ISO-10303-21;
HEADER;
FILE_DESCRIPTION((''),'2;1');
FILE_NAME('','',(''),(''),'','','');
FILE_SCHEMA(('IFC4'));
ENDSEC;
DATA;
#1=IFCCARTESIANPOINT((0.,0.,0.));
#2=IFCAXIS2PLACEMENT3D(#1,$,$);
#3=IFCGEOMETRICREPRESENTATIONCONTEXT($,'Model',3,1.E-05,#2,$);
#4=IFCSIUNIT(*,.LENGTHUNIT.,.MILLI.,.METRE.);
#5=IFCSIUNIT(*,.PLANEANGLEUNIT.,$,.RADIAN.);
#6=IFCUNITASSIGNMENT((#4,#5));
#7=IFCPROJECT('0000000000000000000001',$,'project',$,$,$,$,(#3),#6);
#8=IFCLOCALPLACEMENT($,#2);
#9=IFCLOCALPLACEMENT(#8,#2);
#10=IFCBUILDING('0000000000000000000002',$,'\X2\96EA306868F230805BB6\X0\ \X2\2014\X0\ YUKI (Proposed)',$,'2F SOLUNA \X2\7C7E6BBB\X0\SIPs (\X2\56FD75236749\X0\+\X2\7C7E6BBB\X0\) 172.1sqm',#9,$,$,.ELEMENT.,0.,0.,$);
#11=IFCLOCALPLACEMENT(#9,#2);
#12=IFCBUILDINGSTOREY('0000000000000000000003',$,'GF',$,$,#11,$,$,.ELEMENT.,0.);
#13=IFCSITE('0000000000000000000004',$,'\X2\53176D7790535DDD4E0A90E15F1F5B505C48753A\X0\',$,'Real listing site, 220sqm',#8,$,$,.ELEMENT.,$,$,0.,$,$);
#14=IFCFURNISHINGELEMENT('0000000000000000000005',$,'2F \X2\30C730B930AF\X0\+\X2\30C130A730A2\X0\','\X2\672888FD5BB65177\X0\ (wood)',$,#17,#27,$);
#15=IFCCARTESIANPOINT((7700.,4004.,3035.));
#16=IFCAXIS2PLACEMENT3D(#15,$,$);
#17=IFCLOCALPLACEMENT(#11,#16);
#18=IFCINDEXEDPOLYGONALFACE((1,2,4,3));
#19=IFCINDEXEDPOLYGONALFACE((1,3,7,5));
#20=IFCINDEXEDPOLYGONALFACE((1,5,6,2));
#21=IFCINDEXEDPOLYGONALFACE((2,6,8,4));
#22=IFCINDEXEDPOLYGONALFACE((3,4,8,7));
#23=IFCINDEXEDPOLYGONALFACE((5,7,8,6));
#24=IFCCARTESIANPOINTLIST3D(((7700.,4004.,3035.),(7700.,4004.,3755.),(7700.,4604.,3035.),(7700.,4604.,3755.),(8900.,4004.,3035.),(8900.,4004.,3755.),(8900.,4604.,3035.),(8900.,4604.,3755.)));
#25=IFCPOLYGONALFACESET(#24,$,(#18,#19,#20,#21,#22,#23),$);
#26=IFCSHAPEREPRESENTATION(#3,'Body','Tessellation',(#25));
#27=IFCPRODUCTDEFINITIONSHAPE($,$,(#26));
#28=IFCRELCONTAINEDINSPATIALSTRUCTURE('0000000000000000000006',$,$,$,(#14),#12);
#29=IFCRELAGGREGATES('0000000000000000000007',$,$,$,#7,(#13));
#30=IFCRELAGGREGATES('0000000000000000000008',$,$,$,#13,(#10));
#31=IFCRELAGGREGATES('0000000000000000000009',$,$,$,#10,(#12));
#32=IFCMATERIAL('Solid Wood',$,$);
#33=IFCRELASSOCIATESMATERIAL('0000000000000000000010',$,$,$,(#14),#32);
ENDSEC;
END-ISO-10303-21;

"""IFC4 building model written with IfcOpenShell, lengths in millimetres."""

from ifc_helpers import new_model, si_unit, frame, frame_2d, origin, place, context, project, spatial, rectangle, extrude, material, element, save


model = new_model("IFC4")

# Units and contexts
model_context = context("Model", 3, precision=1e-05, world=origin())
ifc_project = project(units=[si_unit("LENGTHUNIT", "METRE", prefix="MILLI"), si_unit("PLANEANGLEUNIT", "RADIAN")], contexts=[model_context])

# Site, building, storey
site_placement = place(None, origin())
site = spatial("IfcSite", under=ifc_project, at=site_placement, Name="北海道川上郡弟子屈町", ObjectType="Real listing site, 220sqm", CompositionType="ELEMENT", RefElevation=0.0)
building_placement = place(site_placement, origin())
building = spatial("IfcBuilding", under=site, at=building_placement, Name="雪と棲む家 — YUKI (Proposed)", ObjectType="2F SOLUNA 籾殻SIPs (国産杉+籾殻) 172.1sqm", CompositionType="ELEMENT", ElevationOfRefHeight=0.0, ElevationOfTerrain=0.0)
storey_placement = place(building_placement, origin())
storey = spatial("IfcBuildingStorey", under=building, at=storey_placement, Name="GF", CompositionType="ELEMENT", Elevation=0.0)

# Shared definitions
ifc_material_1 = material(Name="Solid Wood")

# Furnishing element
furnishing_1_placement = place(storey_placement, frame((7700.0, 4004.0, 3035.0)))
element("IfcFurnishingElement", 1, at=furnishing_1_placement, inside=storey, material=ifc_material_1, Name="2F デスク+チェア", Description="木製家具 (wood)", context=model_context, shape_type="SweptSolid", body=[
    extrude(rectangle(XDim=1200.0, YDim=600.0, at=frame_2d((600.0, 300.0))), frame((7700.0, 4004.0, 3035.0)), (0.0, 0.0, 1.0), 720.0),
])

save(model, "model.ifc")
